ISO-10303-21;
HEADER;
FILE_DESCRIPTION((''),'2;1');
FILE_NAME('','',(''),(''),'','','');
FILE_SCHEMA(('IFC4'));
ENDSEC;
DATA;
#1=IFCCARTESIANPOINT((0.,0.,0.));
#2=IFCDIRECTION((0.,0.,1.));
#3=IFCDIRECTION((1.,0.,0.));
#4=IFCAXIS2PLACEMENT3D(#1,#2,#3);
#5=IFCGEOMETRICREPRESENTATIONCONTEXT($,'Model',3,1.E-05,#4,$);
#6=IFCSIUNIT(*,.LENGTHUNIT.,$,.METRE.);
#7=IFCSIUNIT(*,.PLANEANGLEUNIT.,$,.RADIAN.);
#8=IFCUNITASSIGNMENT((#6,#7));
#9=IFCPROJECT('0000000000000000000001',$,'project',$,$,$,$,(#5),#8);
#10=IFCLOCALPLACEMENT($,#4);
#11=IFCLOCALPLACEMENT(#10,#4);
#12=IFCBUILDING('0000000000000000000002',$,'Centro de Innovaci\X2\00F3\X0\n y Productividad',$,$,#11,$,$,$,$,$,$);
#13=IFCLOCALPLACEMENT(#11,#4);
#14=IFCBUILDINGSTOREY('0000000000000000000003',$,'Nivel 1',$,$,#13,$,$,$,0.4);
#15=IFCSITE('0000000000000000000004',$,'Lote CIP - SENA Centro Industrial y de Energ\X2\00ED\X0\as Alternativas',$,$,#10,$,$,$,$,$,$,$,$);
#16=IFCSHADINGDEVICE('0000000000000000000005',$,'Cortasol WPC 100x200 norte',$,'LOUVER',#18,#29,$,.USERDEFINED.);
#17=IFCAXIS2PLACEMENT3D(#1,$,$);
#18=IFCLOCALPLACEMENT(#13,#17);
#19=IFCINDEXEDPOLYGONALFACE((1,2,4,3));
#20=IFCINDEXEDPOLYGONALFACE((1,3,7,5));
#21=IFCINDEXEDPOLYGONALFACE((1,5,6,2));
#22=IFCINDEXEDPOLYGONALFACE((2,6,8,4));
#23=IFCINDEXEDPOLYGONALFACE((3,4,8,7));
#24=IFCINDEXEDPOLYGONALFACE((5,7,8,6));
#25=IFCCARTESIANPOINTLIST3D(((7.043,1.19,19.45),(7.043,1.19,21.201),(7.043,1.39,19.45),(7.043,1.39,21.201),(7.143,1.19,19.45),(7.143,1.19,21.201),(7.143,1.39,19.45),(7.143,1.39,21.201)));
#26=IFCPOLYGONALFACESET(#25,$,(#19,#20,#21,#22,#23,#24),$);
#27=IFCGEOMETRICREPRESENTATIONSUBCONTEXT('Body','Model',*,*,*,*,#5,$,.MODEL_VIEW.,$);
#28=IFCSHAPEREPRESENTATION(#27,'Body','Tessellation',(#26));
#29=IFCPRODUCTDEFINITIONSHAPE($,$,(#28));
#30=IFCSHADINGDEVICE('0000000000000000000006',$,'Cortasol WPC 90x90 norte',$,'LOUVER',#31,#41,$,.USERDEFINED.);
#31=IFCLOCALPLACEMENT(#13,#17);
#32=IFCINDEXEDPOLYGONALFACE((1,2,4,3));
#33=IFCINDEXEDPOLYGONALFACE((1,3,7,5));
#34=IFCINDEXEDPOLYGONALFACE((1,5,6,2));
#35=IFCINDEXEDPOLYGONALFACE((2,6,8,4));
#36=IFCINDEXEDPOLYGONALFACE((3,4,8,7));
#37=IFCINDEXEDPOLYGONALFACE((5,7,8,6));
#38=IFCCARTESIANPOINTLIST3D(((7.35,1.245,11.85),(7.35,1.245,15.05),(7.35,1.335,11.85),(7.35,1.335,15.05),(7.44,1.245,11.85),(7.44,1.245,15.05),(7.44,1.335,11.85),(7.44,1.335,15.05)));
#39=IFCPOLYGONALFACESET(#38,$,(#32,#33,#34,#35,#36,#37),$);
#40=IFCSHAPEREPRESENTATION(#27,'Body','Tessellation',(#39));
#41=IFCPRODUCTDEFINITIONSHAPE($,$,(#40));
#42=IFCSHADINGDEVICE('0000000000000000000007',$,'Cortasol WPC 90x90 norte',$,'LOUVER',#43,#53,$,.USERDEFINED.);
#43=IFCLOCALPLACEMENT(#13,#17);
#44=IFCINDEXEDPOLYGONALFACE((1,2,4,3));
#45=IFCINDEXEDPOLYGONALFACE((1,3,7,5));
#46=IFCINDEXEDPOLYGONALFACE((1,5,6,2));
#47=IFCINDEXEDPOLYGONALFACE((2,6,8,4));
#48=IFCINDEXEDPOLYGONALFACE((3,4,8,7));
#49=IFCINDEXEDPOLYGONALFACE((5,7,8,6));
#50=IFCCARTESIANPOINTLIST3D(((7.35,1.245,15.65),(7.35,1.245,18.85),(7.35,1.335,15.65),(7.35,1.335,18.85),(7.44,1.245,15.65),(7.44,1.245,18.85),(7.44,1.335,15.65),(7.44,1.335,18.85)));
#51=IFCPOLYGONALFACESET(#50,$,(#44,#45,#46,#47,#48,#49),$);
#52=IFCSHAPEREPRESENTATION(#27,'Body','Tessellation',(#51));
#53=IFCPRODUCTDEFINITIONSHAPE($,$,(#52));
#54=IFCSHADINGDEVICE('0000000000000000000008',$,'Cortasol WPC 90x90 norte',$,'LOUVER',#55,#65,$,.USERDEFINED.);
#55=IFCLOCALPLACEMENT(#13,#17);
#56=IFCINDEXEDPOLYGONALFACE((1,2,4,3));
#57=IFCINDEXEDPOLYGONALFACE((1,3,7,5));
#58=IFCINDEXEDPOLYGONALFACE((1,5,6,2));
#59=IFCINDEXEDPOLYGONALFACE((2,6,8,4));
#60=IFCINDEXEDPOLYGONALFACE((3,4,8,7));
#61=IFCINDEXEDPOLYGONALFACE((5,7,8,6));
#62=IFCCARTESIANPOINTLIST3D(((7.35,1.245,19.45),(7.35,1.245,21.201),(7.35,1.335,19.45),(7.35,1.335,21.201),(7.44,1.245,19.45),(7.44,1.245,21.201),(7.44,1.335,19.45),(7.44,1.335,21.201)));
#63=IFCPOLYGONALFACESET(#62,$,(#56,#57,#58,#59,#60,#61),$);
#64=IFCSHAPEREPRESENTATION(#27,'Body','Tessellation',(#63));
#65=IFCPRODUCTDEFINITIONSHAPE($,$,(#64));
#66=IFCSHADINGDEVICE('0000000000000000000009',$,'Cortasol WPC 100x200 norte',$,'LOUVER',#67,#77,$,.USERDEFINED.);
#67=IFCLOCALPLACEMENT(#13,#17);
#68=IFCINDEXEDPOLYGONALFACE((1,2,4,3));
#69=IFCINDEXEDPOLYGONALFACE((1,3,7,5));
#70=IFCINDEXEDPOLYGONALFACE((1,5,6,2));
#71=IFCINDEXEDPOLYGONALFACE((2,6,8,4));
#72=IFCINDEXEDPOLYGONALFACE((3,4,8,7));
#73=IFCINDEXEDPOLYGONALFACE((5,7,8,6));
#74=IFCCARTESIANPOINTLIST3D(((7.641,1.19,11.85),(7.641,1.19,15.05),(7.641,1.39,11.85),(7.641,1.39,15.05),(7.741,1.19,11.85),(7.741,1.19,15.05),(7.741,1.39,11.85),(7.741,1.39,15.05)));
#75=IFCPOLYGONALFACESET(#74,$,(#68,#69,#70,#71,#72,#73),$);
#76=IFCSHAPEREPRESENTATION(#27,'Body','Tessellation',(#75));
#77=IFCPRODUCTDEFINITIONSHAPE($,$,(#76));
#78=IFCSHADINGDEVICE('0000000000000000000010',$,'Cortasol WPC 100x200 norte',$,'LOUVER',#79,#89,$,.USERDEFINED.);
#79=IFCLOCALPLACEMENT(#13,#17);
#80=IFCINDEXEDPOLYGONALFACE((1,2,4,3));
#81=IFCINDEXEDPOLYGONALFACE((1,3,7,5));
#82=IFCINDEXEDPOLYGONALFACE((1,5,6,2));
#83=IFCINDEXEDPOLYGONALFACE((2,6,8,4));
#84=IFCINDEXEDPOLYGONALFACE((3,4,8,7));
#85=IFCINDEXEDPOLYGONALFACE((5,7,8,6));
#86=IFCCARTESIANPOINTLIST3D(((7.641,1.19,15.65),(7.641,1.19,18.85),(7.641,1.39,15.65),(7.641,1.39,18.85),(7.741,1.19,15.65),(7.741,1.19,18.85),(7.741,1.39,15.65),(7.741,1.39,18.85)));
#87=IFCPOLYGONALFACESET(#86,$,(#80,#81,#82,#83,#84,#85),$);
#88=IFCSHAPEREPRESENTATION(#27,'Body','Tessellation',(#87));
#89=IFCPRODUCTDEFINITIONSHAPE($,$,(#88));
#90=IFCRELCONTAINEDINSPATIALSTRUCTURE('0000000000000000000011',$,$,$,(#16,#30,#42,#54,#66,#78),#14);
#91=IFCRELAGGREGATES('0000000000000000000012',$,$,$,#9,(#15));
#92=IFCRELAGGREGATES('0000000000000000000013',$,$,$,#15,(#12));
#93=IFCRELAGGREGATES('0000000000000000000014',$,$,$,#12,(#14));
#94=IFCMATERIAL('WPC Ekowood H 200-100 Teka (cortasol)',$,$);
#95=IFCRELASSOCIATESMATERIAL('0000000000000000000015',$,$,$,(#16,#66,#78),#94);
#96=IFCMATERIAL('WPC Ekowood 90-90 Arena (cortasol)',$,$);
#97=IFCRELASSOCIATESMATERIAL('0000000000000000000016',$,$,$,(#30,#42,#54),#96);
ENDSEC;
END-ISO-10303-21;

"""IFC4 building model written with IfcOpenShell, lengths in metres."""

from ifc_helpers import new_model, si_unit, frame, origin_with_axes, place, context, subcontext, project, spatial, polyline, outline, extrude, material, element, save


model = new_model("IFC4")

# Units and contexts
model_context = context("Model", 3, precision=1e-05, world=origin_with_axes())
body_context = subcontext(model_context, "Body", "Model", "MODEL_VIEW")
ifc_project = project(units=[si_unit("LENGTHUNIT", "METRE"), si_unit("PLANEANGLEUNIT", "RADIAN")], contexts=[model_context])

# Site, building, storey
site_placement = place(None, origin_with_axes())
site = spatial("IfcSite", under=ifc_project, at=site_placement, Name="Lote CIP - SENA Centro Industrial y de Energías Alternativas")
building_placement = place(site_placement, origin_with_axes())
building = spatial("IfcBuilding", under=site, at=building_placement, Name="Centro de Innovación y Productividad")
storey_placement = place(building_placement, origin_with_axes())
storey = spatial("IfcBuildingStorey", under=building, at=storey_placement, Name="Nivel 1", Elevation=0.4)

# Shading devices
ifc_material_1 = material(Name="WPC Ekowood 90-90 Arena (cortasol)")
ifc_material_2 = material(Name="WPC Ekowood H 200-100 Teka (cortasol)")
shading_device_1_placement = place(storey_placement, origin_with_axes())
element("IfcShadingDevice", 1, at=shading_device_1_placement, inside=storey, material=ifc_material_2, Name="Cortasol WPC 100x200 norte", ObjectType="LOUVER", PredefinedType="USERDEFINED", context=body_context, shape_type="SweptSolid", body=[
    extrude(outline(polyline([(7.043, 1.19), (7.043, 1.39), (7.143, 1.39), (7.143, 1.19), (7.043, 1.19)])), frame((0.0, 0.0, 19.45)), (0.0, 0.0, 1.0), 1.751),
])
shading_device_2_placement = place(storey_placement, origin_with_axes())
element("IfcShadingDevice", 2, at=shading_device_2_placement, inside=storey, material=ifc_material_1, Name="Cortasol WPC 90x90 norte", ObjectType="LOUVER", PredefinedType="USERDEFINED", context=body_context, shape_type="SweptSolid", body=[
    extrude(outline(polyline([(7.35, 1.245), (7.35, 1.335), (7.44, 1.335), (7.44, 1.245), (7.35, 1.245)])), frame((0.0, 0.0, 11.85)), (0.0, 0.0, 1.0), 3.2),
])
shading_device_3_placement = place(storey_placement, origin_with_axes())
element("IfcShadingDevice", 3, at=shading_device_3_placement, inside=storey, material=ifc_material_1, Name="Cortasol WPC 90x90 norte", ObjectType="LOUVER", PredefinedType="USERDEFINED", context=body_context, shape_type="SweptSolid", body=[
    extrude(outline(polyline([(7.35, 1.245), (7.35, 1.335), (7.44, 1.335), (7.44, 1.245), (7.35, 1.245)])), frame((0.0, 0.0, 15.65)), (0.0, 0.0, 1.0), 3.2),
])
shading_device_4_placement = place(storey_placement, origin_with_axes())
element("IfcShadingDevice", 4, at=shading_device_4_placement, inside=storey, material=ifc_material_1, Name="Cortasol WPC 90x90 norte", ObjectType="LOUVER", PredefinedType="USERDEFINED", context=body_context, shape_type="SweptSolid", body=[
    extrude(outline(polyline([(7.35, 1.245), (7.35, 1.335), (7.44, 1.335), (7.44, 1.245), (7.35, 1.245)])), frame((0.0, 0.0, 19.45)), (0.0, 0.0, 1.0), 1.751),
])
shading_device_5_placement = place(storey_placement, origin_with_axes())
element("IfcShadingDevice", 5, at=shading_device_5_placement, inside=storey, material=ifc_material_2, Name="Cortasol WPC 100x200 norte", ObjectType="LOUVER", PredefinedType="USERDEFINED", context=body_context, shape_type="SweptSolid", body=[
    extrude(outline(polyline([(7.641, 1.19), (7.641, 1.39), (7.741, 1.39), (7.741, 1.19), (7.641, 1.19)])), frame((0.0, 0.0, 11.85)), (0.0, 0.0, 1.0), 3.2),
])
shading_device_6_placement = place(storey_placement, origin_with_axes())
element("IfcShadingDevice", 6, at=shading_device_6_placement, inside=storey, material=ifc_material_2, Name="Cortasol WPC 100x200 norte", ObjectType="LOUVER", PredefinedType="USERDEFINED", context=body_context, shape_type="SweptSolid", body=[
    extrude(outline(polyline([(7.641, 1.19), (7.641, 1.39), (7.741, 1.39), (7.741, 1.19), (7.641, 1.19)])), frame((0.0, 0.0, 15.65)), (0.0, 0.0, 1.0), 3.2),
])

save(model, "model.ifc")
